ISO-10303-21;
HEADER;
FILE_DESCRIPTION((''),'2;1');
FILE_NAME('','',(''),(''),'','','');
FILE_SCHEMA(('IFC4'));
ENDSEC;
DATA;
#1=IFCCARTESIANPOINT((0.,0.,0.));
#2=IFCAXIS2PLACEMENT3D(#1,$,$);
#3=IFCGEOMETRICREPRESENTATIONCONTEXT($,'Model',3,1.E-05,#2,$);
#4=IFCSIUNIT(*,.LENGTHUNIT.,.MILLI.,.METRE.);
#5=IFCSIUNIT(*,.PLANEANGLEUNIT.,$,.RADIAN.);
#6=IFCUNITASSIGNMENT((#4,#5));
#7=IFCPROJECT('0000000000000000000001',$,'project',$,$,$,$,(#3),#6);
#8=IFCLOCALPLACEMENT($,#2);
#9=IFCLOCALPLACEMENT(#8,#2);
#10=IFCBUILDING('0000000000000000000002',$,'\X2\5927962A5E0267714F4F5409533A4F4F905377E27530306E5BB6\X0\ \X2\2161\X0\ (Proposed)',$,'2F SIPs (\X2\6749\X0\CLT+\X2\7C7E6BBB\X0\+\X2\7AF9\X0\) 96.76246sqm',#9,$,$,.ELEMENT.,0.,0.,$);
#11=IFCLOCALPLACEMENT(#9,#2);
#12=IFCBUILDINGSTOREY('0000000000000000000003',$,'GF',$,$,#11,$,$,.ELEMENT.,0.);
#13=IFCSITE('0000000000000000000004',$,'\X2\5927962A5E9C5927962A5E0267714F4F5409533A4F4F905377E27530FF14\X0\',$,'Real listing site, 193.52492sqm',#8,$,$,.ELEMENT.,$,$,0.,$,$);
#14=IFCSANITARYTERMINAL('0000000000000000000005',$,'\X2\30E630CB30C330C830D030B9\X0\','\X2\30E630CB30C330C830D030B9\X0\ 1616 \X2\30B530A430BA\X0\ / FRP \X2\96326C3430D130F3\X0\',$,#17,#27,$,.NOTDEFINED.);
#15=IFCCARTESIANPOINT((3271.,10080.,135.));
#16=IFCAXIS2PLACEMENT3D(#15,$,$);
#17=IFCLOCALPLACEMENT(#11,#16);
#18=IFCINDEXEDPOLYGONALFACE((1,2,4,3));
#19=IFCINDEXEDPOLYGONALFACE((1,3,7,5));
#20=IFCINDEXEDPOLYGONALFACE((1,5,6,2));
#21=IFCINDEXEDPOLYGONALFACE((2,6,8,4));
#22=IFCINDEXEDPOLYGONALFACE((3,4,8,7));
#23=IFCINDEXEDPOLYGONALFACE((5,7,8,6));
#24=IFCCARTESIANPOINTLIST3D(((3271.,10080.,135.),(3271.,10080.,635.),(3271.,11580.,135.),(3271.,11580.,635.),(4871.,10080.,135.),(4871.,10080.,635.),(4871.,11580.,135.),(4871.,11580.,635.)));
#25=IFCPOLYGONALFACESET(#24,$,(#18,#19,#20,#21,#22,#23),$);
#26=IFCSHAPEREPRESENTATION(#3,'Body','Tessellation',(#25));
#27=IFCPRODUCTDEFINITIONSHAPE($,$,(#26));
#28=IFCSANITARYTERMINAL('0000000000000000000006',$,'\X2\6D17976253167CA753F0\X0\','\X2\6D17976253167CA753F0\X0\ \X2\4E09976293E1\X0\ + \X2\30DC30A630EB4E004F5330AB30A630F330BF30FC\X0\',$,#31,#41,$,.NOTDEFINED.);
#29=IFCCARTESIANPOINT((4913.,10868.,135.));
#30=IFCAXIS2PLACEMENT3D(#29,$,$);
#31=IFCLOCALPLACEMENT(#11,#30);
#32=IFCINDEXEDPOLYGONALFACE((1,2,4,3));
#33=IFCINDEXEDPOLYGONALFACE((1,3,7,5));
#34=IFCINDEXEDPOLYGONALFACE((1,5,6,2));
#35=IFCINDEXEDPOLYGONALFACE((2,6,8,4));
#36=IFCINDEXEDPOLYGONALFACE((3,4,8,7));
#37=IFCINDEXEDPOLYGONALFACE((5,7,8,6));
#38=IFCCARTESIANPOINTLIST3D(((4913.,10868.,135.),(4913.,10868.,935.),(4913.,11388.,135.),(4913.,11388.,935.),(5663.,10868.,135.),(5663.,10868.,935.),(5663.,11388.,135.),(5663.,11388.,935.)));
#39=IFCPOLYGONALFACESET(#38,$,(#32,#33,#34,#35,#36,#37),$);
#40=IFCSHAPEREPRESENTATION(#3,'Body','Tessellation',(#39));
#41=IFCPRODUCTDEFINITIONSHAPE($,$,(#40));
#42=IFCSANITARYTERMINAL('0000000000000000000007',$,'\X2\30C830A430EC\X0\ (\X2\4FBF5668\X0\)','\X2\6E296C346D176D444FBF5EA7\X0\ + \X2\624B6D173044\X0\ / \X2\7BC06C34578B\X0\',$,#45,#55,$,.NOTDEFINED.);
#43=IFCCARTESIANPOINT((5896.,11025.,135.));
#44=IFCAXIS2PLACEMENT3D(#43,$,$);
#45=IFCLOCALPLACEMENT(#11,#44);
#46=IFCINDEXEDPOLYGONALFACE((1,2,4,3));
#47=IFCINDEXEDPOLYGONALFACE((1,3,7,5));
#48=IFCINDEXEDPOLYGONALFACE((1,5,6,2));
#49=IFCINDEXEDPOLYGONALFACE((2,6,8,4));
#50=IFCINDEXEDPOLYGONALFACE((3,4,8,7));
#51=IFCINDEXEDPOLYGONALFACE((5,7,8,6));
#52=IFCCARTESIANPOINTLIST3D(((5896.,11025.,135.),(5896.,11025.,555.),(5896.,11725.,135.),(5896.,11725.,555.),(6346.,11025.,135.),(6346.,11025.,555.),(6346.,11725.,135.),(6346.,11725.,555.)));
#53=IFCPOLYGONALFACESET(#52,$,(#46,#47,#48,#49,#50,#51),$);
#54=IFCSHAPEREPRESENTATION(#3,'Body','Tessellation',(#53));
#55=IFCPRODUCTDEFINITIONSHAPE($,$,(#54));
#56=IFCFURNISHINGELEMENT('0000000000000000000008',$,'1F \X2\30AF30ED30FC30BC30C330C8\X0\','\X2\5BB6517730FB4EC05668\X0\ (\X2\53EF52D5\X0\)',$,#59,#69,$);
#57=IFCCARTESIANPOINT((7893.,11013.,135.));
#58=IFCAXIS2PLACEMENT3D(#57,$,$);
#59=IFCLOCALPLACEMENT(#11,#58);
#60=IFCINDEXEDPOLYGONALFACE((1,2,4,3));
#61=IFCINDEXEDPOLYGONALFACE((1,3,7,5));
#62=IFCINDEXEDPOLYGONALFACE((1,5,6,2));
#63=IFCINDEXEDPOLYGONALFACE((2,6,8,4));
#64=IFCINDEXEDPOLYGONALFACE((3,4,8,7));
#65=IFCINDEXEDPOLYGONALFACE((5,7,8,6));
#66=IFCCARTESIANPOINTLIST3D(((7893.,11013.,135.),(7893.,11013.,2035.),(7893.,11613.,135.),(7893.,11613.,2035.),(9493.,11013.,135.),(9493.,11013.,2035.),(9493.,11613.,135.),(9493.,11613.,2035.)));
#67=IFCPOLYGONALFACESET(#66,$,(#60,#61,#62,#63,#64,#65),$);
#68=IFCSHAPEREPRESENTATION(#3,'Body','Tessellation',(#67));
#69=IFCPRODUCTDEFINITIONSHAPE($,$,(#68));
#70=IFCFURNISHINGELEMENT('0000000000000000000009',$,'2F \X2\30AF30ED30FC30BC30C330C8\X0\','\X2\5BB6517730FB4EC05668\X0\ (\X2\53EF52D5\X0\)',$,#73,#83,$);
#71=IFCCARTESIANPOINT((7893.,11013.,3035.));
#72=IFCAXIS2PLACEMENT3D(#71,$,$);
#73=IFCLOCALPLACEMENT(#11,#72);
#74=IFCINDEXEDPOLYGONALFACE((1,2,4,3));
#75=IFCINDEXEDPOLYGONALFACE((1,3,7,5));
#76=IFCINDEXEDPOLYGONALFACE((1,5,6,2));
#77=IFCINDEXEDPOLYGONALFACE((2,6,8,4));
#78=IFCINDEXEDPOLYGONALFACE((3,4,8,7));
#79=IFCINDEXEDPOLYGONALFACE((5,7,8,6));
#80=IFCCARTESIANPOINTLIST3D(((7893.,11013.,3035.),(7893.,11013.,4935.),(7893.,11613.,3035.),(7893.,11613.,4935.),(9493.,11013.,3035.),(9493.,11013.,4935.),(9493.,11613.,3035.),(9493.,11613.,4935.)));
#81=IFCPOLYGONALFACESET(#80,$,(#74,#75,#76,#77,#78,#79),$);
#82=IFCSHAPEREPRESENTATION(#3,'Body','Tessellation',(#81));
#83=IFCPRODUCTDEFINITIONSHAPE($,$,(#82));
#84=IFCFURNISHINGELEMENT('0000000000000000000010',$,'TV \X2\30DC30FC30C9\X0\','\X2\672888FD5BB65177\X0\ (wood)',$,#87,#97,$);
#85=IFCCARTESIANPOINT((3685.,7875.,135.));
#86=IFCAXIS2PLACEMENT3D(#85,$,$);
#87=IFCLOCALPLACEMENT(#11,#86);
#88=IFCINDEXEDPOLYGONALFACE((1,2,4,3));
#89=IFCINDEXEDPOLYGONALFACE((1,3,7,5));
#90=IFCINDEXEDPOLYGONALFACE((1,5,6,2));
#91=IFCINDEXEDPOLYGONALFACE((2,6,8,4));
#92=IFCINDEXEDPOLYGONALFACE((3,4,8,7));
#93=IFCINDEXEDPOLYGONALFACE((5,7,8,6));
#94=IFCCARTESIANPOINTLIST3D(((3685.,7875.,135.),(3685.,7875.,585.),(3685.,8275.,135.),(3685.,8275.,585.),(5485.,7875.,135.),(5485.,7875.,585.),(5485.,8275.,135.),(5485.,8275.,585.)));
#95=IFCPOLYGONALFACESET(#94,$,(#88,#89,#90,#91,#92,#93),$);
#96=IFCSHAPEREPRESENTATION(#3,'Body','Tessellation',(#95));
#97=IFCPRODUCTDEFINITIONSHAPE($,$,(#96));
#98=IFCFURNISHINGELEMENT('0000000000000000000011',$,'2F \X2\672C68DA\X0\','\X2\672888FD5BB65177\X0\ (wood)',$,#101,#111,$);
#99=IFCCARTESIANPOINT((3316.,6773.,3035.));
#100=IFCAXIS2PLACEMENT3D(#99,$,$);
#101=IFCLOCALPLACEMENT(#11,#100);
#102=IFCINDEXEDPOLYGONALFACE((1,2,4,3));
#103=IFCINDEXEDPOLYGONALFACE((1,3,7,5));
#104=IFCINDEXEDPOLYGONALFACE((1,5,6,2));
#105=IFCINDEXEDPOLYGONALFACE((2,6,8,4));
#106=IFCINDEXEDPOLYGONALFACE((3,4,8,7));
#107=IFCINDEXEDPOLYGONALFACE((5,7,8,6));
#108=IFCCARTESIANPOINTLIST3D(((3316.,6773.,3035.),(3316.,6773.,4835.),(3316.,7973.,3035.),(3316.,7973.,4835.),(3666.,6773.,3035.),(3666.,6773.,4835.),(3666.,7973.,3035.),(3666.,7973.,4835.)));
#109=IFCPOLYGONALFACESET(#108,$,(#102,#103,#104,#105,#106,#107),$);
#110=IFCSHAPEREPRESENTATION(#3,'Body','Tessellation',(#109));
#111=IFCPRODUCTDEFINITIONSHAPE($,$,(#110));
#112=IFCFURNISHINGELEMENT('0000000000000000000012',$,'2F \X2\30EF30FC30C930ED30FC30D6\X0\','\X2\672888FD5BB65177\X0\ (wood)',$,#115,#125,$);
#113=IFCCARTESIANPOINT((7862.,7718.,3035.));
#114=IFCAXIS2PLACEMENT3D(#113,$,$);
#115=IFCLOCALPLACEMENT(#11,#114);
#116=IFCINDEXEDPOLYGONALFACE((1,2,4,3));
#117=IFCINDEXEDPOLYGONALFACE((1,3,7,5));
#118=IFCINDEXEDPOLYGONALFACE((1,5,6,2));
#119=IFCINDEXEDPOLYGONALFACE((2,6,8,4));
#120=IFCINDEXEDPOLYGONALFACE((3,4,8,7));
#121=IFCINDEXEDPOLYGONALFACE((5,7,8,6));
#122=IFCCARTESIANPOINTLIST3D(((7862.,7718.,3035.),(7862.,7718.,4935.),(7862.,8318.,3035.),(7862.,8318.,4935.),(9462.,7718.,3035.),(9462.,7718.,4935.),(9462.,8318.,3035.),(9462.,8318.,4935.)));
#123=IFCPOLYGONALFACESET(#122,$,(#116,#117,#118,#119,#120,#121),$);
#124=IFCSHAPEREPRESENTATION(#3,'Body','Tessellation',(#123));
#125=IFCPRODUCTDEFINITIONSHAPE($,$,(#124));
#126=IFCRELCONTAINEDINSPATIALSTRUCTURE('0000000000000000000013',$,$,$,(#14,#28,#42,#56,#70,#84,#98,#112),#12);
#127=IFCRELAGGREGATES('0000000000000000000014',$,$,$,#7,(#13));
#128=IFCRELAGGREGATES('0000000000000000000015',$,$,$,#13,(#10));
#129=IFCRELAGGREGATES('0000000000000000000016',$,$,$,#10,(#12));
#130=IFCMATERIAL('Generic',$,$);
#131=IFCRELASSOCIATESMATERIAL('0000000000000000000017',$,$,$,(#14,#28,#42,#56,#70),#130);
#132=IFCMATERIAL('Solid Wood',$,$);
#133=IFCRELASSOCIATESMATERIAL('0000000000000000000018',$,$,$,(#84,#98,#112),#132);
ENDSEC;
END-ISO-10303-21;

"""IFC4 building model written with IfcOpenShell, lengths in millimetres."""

from ifc_helpers import new_model, si_unit, frame, frame_2d, origin, place, context, project, spatial, rectangle, extrude, material, element, save


model = new_model("IFC4")

# Units and contexts
model_context = context("Model", 3, precision=1e-05, world=origin())
ifc_project = project(units=[si_unit("LENGTHUNIT", "METRE", prefix="MILLI"), si_unit("PLANEANGLEUNIT", "RADIAN")], contexts=[model_context])

# Site, building, storey
site_placement = place(None, origin())
site = spatial("IfcSite", under=ifc_project, at=site_placement, Name="大阪府大阪市東住吉区住道矢田４", ObjectType="Real listing site, 193.52492sqm", CompositionType="ELEMENT", RefElevation=0.0)
building_placement = place(site_placement, origin())
building = spatial("IfcBuilding", under=site, at=building_placement, Name="大阪市東住吉区住道矢田の家 Ⅱ (Proposed)", ObjectType="2F SIPs (杉CLT+籾殻+竹) 96.76246sqm", CompositionType="ELEMENT", ElevationOfRefHeight=0.0, ElevationOfTerrain=0.0)
storey_placement = place(building_placement, origin())
storey = spatial("IfcBuildingStorey", under=building, at=storey_placement, Name="GF", CompositionType="ELEMENT", Elevation=0.0)

# Shared definitions
ifc_material_1 = material(Name="Solid Wood")

# Sanitary terminals
ifc_material_2 = material(Name="Generic")
sanitary_terminal_1_placement = place(storey_placement, frame((3271.0, 10080.0, 135.0)))
element("IfcSanitaryTerminal", 1, at=sanitary_terminal_1_placement, inside=storey, material=ifc_material_2, Name="ユニットバス", Description="ユニットバス 1616 サイズ / FRP 防水パン", PredefinedType="NOTDEFINED", context=model_context, shape_type="SweptSolid", body=[
    extrude(rectangle(XDim=1600.0, YDim=1500.0, at=frame_2d((800.0, 750.0))), frame((3271.0, 10080.0, 135.0)), (0.0, 0.0, 1.0), 500.0),
])
sanitary_terminal_2_placement = place(storey_placement, frame((4913.0, 10868.0, 135.0)))
element("IfcSanitaryTerminal", 2, at=sanitary_terminal_2_placement, inside=storey, material=ifc_material_2, Name="洗面化粧台", Description="洗面化粧台 三面鏡 + ボウル一体カウンター", PredefinedType="NOTDEFINED", context=model_context, shape_type="SweptSolid", body=[
    extrude(rectangle(XDim=750.0, YDim=520.0, at=frame_2d((375.0, 260.0))), frame((4913.0, 10868.0, 135.0)), (0.0, 0.0, 1.0), 800.0),
])
sanitary_terminal_3_placement = place(storey_placement, frame((5896.0, 11025.0, 135.0)))
element("IfcSanitaryTerminal", 3, at=sanitary_terminal_3_placement, inside=storey, material=ifc_material_2, Name="トイレ (便器)", Description="温水洗浄便座 + 手洗い / 節水型", PredefinedType="NOTDEFINED", context=model_context, shape_type="SweptSolid", body=[
    extrude(rectangle(XDim=450.0, YDim=700.0, at=frame_2d((225.0, 350.0))), frame((5896.0, 11025.0, 135.0)), (0.0, 0.0, 1.0), 420.0),
])

# Furnishing elements
furnishing_1_placement = place(storey_placement, frame((7893.0, 11013.0, 135.0)))
element("IfcFurnishingElement", 4, at=furnishing_1_placement, inside=storey, material=ifc_material_2, Name="1F クローゼット", Description="家具・什器 (可動)", context=model_context, shape_type="SweptSolid", body=[
    extrude(rectangle(XDim=1600.0, YDim=600.0, at=frame_2d((800.0, 300.0))), frame((7893.0, 11013.0, 135.0)), (0.0, 0.0, 1.0), 1900.0),
])
furnishing_2_placement = place(storey_placement, frame((7893.0, 11013.0, 3035.0)))
element("IfcFurnishingElement", 5, at=furnishing_2_placement, inside=storey, material=ifc_material_2, Name="2F クローゼット", Description="家具・什器 (可動)", context=model_context, shape_type="SweptSolid", body=[
    extrude(rectangle(XDim=1600.0, YDim=600.0, at=frame_2d((800.0, 300.0))), frame((7893.0, 11013.0, 3035.0)), (0.0, 0.0, 1.0), 1900.0),
])
furnishing_3_placement = place(storey_placement, frame((3685.0, 7875.0, 135.0)))
element("IfcFurnishingElement", 6, at=furnishing_3_placement, inside=storey, material=ifc_material_1, Name="TV ボード", Description="木製家具 (wood)", context=model_context, shape_type="SweptSolid", body=[
    extrude(rectangle(XDim=1800.0, YDim=400.0, at=frame_2d((900.0, 200.0))), frame((3685.0, 7875.0, 135.0)), (0.0, 0.0, 1.0), 450.0),
])
furnishing_4_placement = place(storey_placement, frame((3316.0, 6773.0, 3035.0)))
element("IfcFurnishingElement", 7, at=furnishing_4_placement, inside=storey, material=ifc_material_1, Name="2F 本棚", Description="木製家具 (wood)", context=model_context, shape_type="SweptSolid", body=[
    extrude(rectangle(XDim=350.0, YDim=1200.0, at=frame_2d((175.0, 600.0))), frame((3316.0, 6773.0, 3035.0)), (0.0, 0.0, 1.0), 1800.0),
])
furnishing_5_placement = place(storey_placement, frame((7862.0, 7718.0, 3035.0)))
element("IfcFurnishingElement", 8, at=furnishing_5_placement, inside=storey, material=ifc_material_1, Name="2F ワードローブ", Description="木製家具 (wood)", context=model_context, shape_type="SweptSolid", body=[
    extrude(rectangle(XDim=1600.0, YDim=600.0, at=frame_2d((800.0, 300.0))), frame((7862.0, 7718.0, 3035.0)), (0.0, 0.0, 1.0), 1900.0),
])

save(model, "model.ifc")
